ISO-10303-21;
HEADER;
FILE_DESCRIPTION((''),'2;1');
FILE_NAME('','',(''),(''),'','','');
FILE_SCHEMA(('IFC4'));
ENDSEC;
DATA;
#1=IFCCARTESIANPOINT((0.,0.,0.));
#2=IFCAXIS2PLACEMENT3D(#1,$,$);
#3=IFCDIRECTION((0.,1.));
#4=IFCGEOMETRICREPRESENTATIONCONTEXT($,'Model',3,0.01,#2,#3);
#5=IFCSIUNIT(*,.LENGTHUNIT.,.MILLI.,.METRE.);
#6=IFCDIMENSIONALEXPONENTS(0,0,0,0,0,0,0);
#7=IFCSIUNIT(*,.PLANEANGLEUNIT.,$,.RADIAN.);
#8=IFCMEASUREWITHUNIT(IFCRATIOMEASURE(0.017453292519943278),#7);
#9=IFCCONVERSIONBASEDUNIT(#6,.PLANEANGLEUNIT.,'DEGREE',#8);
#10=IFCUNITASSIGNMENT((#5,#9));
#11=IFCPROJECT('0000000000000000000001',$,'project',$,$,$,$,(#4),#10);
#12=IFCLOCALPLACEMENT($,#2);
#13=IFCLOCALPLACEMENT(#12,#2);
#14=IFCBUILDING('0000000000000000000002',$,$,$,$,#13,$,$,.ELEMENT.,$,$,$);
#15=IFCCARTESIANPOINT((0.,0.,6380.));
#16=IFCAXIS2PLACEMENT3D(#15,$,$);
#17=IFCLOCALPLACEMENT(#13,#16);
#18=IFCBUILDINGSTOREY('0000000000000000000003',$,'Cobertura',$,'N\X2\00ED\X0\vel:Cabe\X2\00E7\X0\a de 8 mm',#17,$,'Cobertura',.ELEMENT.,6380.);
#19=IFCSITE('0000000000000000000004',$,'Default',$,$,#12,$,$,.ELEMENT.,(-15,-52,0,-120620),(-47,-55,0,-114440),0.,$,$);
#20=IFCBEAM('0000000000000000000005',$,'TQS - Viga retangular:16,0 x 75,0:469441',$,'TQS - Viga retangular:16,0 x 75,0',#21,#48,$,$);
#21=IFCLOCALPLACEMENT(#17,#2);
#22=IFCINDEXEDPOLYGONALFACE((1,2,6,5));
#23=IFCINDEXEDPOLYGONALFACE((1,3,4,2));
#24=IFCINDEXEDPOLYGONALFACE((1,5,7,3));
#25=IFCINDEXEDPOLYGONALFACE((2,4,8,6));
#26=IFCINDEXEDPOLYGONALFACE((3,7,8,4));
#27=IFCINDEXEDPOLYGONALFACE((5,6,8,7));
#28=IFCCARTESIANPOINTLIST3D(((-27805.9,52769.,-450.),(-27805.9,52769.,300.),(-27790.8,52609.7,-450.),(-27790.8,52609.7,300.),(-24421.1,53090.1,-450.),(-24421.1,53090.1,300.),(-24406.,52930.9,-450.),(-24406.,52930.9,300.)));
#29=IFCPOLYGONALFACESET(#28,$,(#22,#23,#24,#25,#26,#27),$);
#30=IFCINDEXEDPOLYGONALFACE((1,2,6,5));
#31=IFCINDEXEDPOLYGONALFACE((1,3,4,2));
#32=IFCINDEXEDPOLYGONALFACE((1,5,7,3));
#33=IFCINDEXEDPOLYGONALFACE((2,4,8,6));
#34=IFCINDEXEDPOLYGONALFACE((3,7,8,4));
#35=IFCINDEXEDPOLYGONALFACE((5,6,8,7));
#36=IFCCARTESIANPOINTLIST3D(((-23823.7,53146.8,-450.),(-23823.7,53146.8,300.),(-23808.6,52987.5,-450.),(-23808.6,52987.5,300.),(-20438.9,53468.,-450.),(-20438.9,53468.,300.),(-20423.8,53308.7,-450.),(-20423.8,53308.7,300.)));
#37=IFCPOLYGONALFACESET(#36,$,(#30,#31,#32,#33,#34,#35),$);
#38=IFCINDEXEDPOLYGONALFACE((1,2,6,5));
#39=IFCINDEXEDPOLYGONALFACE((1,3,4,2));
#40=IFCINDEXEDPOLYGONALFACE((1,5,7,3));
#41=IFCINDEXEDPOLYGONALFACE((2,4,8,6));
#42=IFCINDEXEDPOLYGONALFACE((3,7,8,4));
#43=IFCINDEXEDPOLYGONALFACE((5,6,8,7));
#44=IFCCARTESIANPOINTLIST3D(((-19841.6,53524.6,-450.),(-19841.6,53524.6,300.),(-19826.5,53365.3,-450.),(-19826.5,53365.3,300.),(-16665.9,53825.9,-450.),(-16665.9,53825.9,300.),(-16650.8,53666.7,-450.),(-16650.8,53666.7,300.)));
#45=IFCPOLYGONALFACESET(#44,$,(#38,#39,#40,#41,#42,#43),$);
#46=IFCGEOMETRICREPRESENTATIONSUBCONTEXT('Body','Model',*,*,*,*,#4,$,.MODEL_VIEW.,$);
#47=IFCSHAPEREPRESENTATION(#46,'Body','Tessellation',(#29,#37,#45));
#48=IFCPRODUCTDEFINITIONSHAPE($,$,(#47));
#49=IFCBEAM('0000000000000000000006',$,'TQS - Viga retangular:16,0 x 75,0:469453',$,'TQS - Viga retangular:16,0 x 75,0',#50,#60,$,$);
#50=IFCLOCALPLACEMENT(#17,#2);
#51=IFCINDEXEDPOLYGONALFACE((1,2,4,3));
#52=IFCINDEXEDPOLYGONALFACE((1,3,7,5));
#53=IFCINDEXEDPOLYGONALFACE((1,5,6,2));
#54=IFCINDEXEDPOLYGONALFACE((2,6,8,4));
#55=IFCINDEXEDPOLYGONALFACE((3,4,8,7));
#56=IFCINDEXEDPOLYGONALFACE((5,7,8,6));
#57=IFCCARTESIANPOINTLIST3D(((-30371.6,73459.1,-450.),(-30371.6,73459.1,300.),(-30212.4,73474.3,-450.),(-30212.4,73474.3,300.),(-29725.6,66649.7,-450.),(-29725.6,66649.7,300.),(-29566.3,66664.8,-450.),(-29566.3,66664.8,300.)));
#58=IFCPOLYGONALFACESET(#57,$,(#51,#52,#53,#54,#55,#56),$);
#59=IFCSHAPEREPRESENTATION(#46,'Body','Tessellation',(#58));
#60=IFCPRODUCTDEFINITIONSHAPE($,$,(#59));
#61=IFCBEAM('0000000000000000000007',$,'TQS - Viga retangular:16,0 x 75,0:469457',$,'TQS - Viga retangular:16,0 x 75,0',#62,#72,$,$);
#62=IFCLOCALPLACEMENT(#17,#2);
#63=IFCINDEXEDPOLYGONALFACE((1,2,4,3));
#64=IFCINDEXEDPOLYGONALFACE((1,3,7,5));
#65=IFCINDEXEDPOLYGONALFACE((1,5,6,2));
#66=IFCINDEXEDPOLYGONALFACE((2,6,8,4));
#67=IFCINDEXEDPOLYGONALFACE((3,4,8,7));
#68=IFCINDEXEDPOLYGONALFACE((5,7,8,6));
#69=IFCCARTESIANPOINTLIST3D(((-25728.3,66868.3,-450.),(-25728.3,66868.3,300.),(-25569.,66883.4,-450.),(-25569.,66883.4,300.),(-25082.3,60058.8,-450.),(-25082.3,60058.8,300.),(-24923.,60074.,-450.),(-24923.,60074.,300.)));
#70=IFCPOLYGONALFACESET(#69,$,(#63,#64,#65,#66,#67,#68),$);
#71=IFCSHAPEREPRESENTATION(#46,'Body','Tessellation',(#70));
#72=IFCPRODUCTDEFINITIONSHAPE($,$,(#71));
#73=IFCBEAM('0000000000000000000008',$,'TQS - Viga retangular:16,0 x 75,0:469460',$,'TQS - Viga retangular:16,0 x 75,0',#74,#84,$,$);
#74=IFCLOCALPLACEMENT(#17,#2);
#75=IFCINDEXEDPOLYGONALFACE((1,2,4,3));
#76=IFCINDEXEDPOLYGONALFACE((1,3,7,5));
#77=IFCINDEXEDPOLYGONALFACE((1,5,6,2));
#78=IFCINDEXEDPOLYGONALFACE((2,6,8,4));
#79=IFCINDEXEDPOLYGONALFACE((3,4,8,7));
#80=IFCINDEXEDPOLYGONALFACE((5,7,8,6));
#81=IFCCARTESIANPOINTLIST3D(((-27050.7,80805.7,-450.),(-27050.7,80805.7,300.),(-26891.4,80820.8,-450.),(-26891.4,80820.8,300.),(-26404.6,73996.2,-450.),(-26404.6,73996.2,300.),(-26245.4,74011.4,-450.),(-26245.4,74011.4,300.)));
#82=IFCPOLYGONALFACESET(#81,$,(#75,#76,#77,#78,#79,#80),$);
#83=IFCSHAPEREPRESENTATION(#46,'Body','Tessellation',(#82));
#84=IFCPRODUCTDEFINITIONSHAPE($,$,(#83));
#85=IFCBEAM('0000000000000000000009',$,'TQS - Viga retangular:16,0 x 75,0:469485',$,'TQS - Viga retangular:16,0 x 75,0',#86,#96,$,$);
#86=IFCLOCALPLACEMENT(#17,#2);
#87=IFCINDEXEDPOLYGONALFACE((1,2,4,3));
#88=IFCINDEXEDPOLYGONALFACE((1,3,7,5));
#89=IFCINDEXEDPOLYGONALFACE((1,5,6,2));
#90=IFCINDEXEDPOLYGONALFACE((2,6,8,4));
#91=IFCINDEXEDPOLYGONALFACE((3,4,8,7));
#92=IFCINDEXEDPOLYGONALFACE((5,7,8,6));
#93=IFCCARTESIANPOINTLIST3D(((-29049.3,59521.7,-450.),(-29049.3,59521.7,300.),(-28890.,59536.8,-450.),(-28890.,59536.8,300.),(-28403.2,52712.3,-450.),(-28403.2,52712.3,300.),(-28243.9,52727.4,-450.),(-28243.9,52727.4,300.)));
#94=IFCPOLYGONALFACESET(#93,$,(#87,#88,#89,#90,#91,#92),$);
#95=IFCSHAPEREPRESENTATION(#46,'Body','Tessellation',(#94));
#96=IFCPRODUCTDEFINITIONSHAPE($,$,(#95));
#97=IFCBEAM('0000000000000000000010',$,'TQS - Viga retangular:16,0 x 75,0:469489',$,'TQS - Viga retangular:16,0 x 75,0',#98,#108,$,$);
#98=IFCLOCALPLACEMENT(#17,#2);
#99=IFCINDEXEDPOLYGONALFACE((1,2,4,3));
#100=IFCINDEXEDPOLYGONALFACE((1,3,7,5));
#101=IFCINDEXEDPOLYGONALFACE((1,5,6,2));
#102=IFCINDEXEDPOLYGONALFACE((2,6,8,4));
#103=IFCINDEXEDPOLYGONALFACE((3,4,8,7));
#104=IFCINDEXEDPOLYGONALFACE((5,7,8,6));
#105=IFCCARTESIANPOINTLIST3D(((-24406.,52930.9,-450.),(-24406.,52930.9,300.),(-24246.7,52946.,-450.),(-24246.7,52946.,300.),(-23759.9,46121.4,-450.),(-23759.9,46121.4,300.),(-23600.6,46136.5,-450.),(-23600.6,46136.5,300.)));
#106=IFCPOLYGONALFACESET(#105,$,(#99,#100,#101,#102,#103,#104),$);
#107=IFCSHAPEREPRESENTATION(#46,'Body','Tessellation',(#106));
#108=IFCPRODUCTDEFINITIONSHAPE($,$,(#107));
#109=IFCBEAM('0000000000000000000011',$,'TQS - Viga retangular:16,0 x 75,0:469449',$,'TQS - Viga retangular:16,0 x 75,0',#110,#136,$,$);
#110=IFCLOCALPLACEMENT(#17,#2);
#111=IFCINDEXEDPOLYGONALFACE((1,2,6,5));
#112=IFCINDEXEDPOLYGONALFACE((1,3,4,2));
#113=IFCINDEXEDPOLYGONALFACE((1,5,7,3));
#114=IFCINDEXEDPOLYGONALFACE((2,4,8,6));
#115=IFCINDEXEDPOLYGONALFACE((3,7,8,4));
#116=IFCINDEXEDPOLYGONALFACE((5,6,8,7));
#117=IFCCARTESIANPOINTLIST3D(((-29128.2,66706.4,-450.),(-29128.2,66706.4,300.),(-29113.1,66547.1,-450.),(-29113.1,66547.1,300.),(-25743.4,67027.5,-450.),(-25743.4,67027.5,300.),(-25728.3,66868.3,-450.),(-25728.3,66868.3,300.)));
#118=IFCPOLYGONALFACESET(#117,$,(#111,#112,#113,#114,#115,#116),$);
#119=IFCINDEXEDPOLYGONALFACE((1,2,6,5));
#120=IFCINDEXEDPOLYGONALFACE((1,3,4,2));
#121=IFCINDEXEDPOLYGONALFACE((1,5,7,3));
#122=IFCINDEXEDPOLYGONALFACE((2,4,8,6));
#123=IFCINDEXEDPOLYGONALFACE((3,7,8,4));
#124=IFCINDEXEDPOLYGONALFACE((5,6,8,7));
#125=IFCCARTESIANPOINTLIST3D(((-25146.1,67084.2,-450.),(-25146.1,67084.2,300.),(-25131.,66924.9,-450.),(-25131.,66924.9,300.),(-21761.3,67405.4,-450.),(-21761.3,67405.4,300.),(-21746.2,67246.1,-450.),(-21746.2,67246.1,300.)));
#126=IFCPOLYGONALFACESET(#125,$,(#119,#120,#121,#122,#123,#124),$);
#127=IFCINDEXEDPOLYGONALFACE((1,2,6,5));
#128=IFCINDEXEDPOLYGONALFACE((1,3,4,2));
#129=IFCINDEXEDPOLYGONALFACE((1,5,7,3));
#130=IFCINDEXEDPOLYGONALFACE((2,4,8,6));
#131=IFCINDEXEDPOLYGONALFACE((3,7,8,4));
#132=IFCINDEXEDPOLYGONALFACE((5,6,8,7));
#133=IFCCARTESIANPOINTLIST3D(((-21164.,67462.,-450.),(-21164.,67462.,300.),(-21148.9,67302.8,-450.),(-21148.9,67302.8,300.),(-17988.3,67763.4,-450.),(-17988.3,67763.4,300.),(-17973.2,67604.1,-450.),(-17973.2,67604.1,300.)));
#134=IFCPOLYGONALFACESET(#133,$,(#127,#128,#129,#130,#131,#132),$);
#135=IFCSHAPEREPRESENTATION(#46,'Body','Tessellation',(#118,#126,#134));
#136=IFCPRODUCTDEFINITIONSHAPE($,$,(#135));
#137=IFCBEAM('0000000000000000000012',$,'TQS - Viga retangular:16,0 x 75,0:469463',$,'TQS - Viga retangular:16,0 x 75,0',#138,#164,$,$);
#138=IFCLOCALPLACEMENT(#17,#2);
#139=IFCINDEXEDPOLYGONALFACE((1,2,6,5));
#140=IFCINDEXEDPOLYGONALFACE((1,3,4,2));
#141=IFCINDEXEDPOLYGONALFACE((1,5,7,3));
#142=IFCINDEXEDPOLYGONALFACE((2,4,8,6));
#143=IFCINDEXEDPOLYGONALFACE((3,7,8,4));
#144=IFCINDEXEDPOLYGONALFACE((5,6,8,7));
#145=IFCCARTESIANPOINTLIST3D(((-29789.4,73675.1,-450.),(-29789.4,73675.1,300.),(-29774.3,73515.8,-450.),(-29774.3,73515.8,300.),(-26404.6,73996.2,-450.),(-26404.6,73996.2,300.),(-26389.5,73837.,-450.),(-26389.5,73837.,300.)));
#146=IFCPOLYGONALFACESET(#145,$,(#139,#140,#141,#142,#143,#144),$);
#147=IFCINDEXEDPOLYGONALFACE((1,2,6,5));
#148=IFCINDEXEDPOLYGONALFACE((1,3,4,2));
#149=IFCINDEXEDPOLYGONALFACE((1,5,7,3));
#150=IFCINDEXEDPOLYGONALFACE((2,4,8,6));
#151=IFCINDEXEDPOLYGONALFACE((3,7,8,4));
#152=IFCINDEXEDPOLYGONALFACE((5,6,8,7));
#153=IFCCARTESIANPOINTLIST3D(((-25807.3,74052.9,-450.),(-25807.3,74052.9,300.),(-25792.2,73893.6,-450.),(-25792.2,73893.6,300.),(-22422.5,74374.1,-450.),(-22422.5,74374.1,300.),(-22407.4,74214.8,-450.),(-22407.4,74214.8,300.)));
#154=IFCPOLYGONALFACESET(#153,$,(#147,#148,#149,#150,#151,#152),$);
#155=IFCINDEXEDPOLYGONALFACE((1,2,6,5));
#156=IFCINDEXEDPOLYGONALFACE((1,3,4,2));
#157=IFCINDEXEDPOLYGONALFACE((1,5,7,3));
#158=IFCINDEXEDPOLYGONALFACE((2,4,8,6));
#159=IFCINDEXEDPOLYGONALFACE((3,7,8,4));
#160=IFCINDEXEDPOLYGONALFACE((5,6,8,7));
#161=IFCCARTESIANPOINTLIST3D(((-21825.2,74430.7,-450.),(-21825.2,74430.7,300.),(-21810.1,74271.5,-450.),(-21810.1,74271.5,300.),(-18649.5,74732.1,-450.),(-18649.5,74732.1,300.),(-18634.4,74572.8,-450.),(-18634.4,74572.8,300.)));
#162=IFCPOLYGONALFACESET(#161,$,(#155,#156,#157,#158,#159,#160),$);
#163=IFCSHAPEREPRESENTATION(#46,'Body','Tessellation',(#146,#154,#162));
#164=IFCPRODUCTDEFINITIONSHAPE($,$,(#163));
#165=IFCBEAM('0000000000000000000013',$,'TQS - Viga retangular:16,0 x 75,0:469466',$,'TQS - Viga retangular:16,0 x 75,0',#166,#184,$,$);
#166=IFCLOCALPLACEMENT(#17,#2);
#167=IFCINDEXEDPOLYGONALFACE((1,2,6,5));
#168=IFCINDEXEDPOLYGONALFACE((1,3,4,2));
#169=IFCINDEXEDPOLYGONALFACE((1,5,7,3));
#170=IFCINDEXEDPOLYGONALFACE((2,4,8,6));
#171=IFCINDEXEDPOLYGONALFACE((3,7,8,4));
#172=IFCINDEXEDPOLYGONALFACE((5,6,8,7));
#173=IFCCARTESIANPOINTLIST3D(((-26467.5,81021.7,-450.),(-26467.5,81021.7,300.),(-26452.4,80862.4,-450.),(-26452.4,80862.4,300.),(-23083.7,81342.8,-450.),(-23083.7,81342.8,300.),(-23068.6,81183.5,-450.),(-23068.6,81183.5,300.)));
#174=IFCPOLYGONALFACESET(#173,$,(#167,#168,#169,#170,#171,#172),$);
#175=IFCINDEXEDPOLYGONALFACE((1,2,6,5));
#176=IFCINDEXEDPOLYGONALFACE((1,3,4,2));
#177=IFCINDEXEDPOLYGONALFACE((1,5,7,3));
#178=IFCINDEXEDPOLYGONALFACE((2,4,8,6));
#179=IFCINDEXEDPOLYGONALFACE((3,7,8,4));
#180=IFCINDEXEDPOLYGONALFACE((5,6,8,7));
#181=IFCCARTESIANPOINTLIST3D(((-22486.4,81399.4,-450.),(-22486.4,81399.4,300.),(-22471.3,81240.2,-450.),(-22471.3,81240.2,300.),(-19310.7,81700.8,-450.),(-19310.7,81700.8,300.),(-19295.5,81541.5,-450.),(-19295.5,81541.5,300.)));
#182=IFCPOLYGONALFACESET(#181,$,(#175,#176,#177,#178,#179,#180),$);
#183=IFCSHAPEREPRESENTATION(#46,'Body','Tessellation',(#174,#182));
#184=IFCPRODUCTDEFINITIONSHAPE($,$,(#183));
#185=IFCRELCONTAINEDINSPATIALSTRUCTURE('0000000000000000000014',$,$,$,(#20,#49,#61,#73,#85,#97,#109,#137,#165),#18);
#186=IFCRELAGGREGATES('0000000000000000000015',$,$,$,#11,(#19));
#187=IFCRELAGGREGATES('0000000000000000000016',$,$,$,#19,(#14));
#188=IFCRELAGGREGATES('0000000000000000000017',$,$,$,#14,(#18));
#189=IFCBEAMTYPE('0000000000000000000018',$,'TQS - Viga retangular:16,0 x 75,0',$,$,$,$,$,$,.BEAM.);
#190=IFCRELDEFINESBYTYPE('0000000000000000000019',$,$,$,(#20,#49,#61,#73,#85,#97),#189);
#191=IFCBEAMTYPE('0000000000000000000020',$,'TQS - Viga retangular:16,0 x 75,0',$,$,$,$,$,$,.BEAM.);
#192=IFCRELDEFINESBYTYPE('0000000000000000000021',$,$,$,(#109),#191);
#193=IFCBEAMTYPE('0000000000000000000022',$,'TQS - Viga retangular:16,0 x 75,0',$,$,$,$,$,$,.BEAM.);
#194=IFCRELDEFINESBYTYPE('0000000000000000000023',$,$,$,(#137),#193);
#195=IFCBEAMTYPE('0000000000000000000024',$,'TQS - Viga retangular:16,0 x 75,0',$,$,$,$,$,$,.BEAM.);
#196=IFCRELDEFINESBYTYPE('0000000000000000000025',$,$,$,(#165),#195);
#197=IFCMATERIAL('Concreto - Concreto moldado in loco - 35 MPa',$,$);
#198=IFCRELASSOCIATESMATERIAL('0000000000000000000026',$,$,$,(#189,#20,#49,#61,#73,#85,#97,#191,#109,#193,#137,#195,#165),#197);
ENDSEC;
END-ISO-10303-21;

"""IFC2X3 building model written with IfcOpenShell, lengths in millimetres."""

from ifc_helpers import new_model, entity, si_unit, converted_unit, direction, frame, frame_2d, origin, origin_2d_with_axis, place, context, subcontext, project, spatial, rectangle, extrude, source, transform, mapped, material, type_object, type_shapes, element, save


model = new_model("IFC2X3")

# Units and contexts
model_context = context("Model", 3, precision=0.01, world=origin(), true_north=direction((0.0, 1.0)))
body_context = subcontext(model_context, "Body", "Model", "MODEL_VIEW")
ifc_project = project(units=[si_unit("LENGTHUNIT", "METRE", prefix="MILLI"), converted_unit("PLANEANGLEUNIT", "DEGREE", entity("IfcRatioMeasure", 0.017453292519943278), si_unit("PLANEANGLEUNIT", "RADIAN"), dimensions=[0, 0, 0, 0, 0, 0, 0])], contexts=[model_context])

# Site, building, storey
site_placement = place(None, origin())
site = spatial("IfcSite", under=ifc_project, at=site_placement, Name="Default", CompositionType="ELEMENT", RefLatitude=(-15, -52, 0, -120620), RefLongitude=(-47, -55, 0, -114440), RefElevation=0.0)
building_placement = place(site_placement, origin())
building = spatial("IfcBuilding", under=site, at=building_placement, CompositionType="ELEMENT")
storey_placement = place(building_placement, frame((0.0, 0.0, 6380.0)))
storey = spatial("IfcBuildingStorey", under=building, at=storey_placement, Name="Cobertura", ObjectType="Nível:Cabeça de 8 mm", LongName="Cobertura", CompositionType="ELEMENT", Elevation=6380.0)

# Beams
ifc_material = material(Name="Concreto - Concreto moldado in loco - 35 MPa")
beam_type_1 = type_object("IfcBeamType", Name="TQS - Viga retangular:16,0 x 75,0", PredefinedType="BEAM", material=ifc_material)
shared_shape_1 = source(origin(), body_context, "Body", "SweptSolid", [
    extrude(rectangle(XDim=750.0, YDim=160.0, at=frame_2d((0.0, 0.0), x_axis=(1.0, 0.0))), frame((-24413.5, 53010.5, 6305.0), z_axis=(-0.995529, -0.094456, 0.0), x_axis=(0.0, 0.0, -1.0)), (0.0, 0.0, 1.0), 3400.0),
    extrude(rectangle(XDim=750.0, YDim=160.0, at=frame_2d((0.0, 0.0), x_axis=(1.0, 0.0))), frame((-20431.4, 53388.3, 6305.0), z_axis=(-0.995529, -0.094456, 0.0), x_axis=(0.0, 0.0, -1.0)), (0.0, 0.0, 1.0), 3400.0),
    extrude(rectangle(XDim=750.0, YDim=160.0, at=frame_2d((0.0, 0.0), x_axis=(1.0, 0.0))), frame((-16658.3, 53746.3, 6305.0), z_axis=(-0.995529, -0.094456, 0.0), x_axis=(0.0, 0.0, -1.0)), (0.0, 0.0, 1.0), 3190.0),
])
type_shapes(beam_type_1, [shared_shape_1])
beam_1_placement = place(storey_placement, frame((0.0, 0.0, -6380.0)))
element("IfcBeam", 1, at=beam_1_placement, inside=storey, type_object=beam_type_1, material=ifc_material, Name="TQS - Viga retangular:16,0 x 75,0:469441", ObjectType="TQS - Viga retangular:16,0 x 75,0", context=body_context, shape_type="MappedRepresentation", body=[
    mapped(shared_shape_1, transform((0.0, 0.0, 0.0), scale=1.0)),
])
beam_2_placement = place(storey_placement, frame((-29638.4, 66577.6, 300.0), z_axis=(0.0, 0.0, 1.0), x_axis=(-0.094456, 0.995529, 0.0)))
element("IfcBeam", 2, at=beam_2_placement, inside=storey, type_object=beam_type_1, material=ifc_material, Name="TQS - Viga retangular:16,0 x 75,0:469453", ObjectType="TQS - Viga retangular:16,0 x 75,0", context=body_context, shape_type="SweptSolid", body=[
    extrude(rectangle(XDim=750.0, YDim=160.0, at=origin_2d_with_axis()), frame((80.0, 0.0, -375.0), z_axis=(1.0, 0.0, 0.0), x_axis=(0.0, 0.0, -1.0)), (0.0, 0.0, 1.0), 6840.0),
])
beam_3_placement = place(storey_placement, frame((-24995.1, 59986.8, 300.0), z_axis=(0.0, 0.0, 1.0), x_axis=(-0.094456, 0.995529, 0.0)))
element("IfcBeam", 3, at=beam_3_placement, inside=storey, type_object=beam_type_1, material=ifc_material, Name="TQS - Viga retangular:16,0 x 75,0:469457", ObjectType="TQS - Viga retangular:16,0 x 75,0", context=body_context, shape_type="SweptSolid", body=[
    extrude(rectangle(XDim=750.0, YDim=160.0, at=frame_2d((0.0, 0.0), x_axis=(1.0, 0.0))), frame((80.0, 0.0, -375.0), z_axis=(1.0, 0.0, 0.0), x_axis=(0.0, 0.0, -1.0)), (0.0, 0.0, 1.0), 6840.0),
])
beam_4_placement = place(storey_placement, frame((-26317.4, 73924.2, 300.0), z_axis=(0.0, 0.0, 1.0), x_axis=(-0.094456, 0.995529, 0.0)))
element("IfcBeam", 4, at=beam_4_placement, inside=storey, type_object=beam_type_1, material=ifc_material, Name="TQS - Viga retangular:16,0 x 75,0:469460", ObjectType="TQS - Viga retangular:16,0 x 75,0", context=body_context, shape_type="SweptSolid", body=[
    extrude(rectangle(XDim=750.0, YDim=160.0, at=frame_2d((0.0, 0.0), x_axis=(1.0, 0.0))), frame((80.0, 0.0, -375.0), z_axis=(1.0, 0.0, 0.0), x_axis=(0.0, 0.0, -1.0)), (0.0, 0.0, 1.0), 6840.0),
])
beam_5_placement = place(storey_placement, frame((-28316.0, 52640.2, 300.0), z_axis=(0.0, 0.0, 1.0), x_axis=(-0.094456, 0.995529, 0.0)))
element("IfcBeam", 5, at=beam_5_placement, inside=storey, type_object=beam_type_1, material=ifc_material, Name="TQS - Viga retangular:16,0 x 75,0:469485", ObjectType="TQS - Viga retangular:16,0 x 75,0", context=body_context, shape_type="SweptSolid", body=[
    extrude(rectangle(XDim=750.0, YDim=160.0, at=frame_2d((0.0, 0.0), x_axis=(1.0, 0.0))), frame((80.0, 0.0, -375.0), z_axis=(1.0, 0.0, 0.0), x_axis=(0.0, 0.0, -1.0)), (0.0, 0.0, 1.0), 6840.0),
])
beam_6_placement = place(storey_placement, frame((-23672.7, 46049.3, 300.0), z_axis=(0.0, 0.0, 1.0), x_axis=(-0.094456, 0.995529, 0.0)))
element("IfcBeam", 6, at=beam_6_placement, inside=storey, type_object=beam_type_1, material=ifc_material, Name="TQS - Viga retangular:16,0 x 75,0:469489", ObjectType="TQS - Viga retangular:16,0 x 75,0", context=body_context, shape_type="SweptSolid", body=[
    extrude(rectangle(XDim=750.0, YDim=160.0, at=frame_2d((0.0, 0.0), x_axis=(1.0, 0.0))), frame((80.0, 0.0, -375.0), z_axis=(1.0, 0.0, 0.0), x_axis=(0.0, 0.0, -1.0)), (0.0, 0.0, 1.0), 6840.0),
])
beam_type_2 = type_object("IfcBeamType", Name="TQS - Viga retangular:16,0 x 75,0", PredefinedType="BEAM", material=ifc_material)
shared_shape_2 = source(origin(), body_context, "Body", "SweptSolid", [
    extrude(rectangle(XDim=750.0, YDim=160.0, at=frame_2d((0.0, 0.0), x_axis=(1.0, 0.0))), frame((-25735.9, 66947.9, 6305.0), z_axis=(-0.995529, -0.094456, 0.0), x_axis=(0.0, 0.0, -1.0)), (0.0, 0.0, 1.0), 3400.0),
    extrude(rectangle(XDim=750.0, YDim=160.0, at=frame_2d((0.0, 0.0), x_axis=(1.0, 0.0))), frame((-21753.8, 67325.7, 6305.0), z_axis=(-0.995529, -0.094456, 0.0), x_axis=(0.0, 0.0, -1.0)), (0.0, 0.0, 1.0), 3400.0),
    extrude(rectangle(XDim=750.0, YDim=160.0, at=origin_2d_with_axis()), frame((-17980.7, 67683.7, 6305.0), z_axis=(-0.995529, -0.094456, 0.0), x_axis=(0.0, 0.0, -1.0)), (0.0, 0.0, 1.0), 3190.0),
])
type_shapes(beam_type_2, [shared_shape_2])
beam_7_placement = place(storey_placement, frame((0.0, 0.0, -6380.0)))
element("IfcBeam", 7, at=beam_7_placement, inside=storey, type_object=beam_type_2, material=ifc_material, Name="TQS - Viga retangular:16,0 x 75,0:469449", ObjectType="TQS - Viga retangular:16,0 x 75,0", context=body_context, shape_type="MappedRepresentation", body=[
    mapped(shared_shape_2, transform((0.0, 0.0, 0.0), scale=1.0)),
])
beam_type_3 = type_object("IfcBeamType", Name="TQS - Viga retangular:16,0 x 75,0", PredefinedType="BEAM", material=ifc_material)
shared_shape_3 = source(origin(), body_context, "Body", "SweptSolid", [
    extrude(rectangle(XDim=750.0, YDim=160.0, at=frame_2d((0.0, 0.0), x_axis=(1.0, 0.0))), frame((-26397.1, 73916.6, 6305.0), z_axis=(-0.995529, -0.094456, 0.0), x_axis=(0.0, 0.0, -1.0)), (0.0, 0.0, 1.0), 3400.0),
    extrude(rectangle(XDim=750.0, YDim=160.0, at=origin_2d_with_axis()), frame((-22415.0, 74294.4, 6305.0), z_axis=(-0.995529, -0.094456, 0.0), x_axis=(0.0, 0.0, -1.0)), (0.0, 0.0, 1.0), 3400.0),
    extrude(rectangle(XDim=750.0, YDim=160.0, at=frame_2d((0.0, 0.0), x_axis=(1.0, 0.0))), frame((-18641.9, 74652.4, 6305.0), z_axis=(-0.995529, -0.094456, 0.0), x_axis=(0.0, 0.0, -1.0)), (0.0, 0.0, 1.0), 3190.0),
])
type_shapes(beam_type_3, [shared_shape_3])
beam_8_placement = place(storey_placement, frame((0.0, 0.0, -6380.0)))
element("IfcBeam", 8, at=beam_8_placement, inside=storey, type_object=beam_type_3, material=ifc_material, Name="TQS - Viga retangular:16,0 x 75,0:469463", ObjectType="TQS - Viga retangular:16,0 x 75,0", context=body_context, shape_type="MappedRepresentation", body=[
    mapped(shared_shape_3, transform((0.0, 0.0, 0.0), scale=1.0)),
])
beam_type_4 = type_object("IfcBeamType", Name="TQS - Viga retangular:16,0 x 75,0", PredefinedType="BEAM", material=ifc_material)
shared_shape_4 = source(origin(), body_context, "Body", "SweptSolid", [
    extrude(rectangle(XDim=750.0, YDim=160.0, at=origin_2d_with_axis()), frame((-23076.2, 81263.1, 6305.0), z_axis=(-0.995529, -0.094456, 0.0), x_axis=(0.0, 0.0, -1.0)), (0.0, 0.0, 1.0), 3399.0),
    extrude(rectangle(XDim=750.0, YDim=160.0, at=frame_2d((0.0, 0.0), x_axis=(1.0, 0.0))), frame((-19303.1, 81621.1, 6305.0), z_axis=(-0.995529, -0.094456, 0.0), x_axis=(0.0, 0.0, -1.0)), (0.0, 0.0, 1.0), 3190.0),
])
type_shapes(beam_type_4, [shared_shape_4])
beam_9_placement = place(storey_placement, frame((0.0, 0.0, -6380.0)))
element("IfcBeam", 9, at=beam_9_placement, inside=storey, type_object=beam_type_4, material=ifc_material, Name="TQS - Viga retangular:16,0 x 75,0:469466", ObjectType="TQS - Viga retangular:16,0 x 75,0", context=body_context, shape_type="MappedRepresentation", body=[
    mapped(shared_shape_4, transform((0.0, 0.0, 0.0), scale=1.0)),
])

save(model, "model.ifc")
